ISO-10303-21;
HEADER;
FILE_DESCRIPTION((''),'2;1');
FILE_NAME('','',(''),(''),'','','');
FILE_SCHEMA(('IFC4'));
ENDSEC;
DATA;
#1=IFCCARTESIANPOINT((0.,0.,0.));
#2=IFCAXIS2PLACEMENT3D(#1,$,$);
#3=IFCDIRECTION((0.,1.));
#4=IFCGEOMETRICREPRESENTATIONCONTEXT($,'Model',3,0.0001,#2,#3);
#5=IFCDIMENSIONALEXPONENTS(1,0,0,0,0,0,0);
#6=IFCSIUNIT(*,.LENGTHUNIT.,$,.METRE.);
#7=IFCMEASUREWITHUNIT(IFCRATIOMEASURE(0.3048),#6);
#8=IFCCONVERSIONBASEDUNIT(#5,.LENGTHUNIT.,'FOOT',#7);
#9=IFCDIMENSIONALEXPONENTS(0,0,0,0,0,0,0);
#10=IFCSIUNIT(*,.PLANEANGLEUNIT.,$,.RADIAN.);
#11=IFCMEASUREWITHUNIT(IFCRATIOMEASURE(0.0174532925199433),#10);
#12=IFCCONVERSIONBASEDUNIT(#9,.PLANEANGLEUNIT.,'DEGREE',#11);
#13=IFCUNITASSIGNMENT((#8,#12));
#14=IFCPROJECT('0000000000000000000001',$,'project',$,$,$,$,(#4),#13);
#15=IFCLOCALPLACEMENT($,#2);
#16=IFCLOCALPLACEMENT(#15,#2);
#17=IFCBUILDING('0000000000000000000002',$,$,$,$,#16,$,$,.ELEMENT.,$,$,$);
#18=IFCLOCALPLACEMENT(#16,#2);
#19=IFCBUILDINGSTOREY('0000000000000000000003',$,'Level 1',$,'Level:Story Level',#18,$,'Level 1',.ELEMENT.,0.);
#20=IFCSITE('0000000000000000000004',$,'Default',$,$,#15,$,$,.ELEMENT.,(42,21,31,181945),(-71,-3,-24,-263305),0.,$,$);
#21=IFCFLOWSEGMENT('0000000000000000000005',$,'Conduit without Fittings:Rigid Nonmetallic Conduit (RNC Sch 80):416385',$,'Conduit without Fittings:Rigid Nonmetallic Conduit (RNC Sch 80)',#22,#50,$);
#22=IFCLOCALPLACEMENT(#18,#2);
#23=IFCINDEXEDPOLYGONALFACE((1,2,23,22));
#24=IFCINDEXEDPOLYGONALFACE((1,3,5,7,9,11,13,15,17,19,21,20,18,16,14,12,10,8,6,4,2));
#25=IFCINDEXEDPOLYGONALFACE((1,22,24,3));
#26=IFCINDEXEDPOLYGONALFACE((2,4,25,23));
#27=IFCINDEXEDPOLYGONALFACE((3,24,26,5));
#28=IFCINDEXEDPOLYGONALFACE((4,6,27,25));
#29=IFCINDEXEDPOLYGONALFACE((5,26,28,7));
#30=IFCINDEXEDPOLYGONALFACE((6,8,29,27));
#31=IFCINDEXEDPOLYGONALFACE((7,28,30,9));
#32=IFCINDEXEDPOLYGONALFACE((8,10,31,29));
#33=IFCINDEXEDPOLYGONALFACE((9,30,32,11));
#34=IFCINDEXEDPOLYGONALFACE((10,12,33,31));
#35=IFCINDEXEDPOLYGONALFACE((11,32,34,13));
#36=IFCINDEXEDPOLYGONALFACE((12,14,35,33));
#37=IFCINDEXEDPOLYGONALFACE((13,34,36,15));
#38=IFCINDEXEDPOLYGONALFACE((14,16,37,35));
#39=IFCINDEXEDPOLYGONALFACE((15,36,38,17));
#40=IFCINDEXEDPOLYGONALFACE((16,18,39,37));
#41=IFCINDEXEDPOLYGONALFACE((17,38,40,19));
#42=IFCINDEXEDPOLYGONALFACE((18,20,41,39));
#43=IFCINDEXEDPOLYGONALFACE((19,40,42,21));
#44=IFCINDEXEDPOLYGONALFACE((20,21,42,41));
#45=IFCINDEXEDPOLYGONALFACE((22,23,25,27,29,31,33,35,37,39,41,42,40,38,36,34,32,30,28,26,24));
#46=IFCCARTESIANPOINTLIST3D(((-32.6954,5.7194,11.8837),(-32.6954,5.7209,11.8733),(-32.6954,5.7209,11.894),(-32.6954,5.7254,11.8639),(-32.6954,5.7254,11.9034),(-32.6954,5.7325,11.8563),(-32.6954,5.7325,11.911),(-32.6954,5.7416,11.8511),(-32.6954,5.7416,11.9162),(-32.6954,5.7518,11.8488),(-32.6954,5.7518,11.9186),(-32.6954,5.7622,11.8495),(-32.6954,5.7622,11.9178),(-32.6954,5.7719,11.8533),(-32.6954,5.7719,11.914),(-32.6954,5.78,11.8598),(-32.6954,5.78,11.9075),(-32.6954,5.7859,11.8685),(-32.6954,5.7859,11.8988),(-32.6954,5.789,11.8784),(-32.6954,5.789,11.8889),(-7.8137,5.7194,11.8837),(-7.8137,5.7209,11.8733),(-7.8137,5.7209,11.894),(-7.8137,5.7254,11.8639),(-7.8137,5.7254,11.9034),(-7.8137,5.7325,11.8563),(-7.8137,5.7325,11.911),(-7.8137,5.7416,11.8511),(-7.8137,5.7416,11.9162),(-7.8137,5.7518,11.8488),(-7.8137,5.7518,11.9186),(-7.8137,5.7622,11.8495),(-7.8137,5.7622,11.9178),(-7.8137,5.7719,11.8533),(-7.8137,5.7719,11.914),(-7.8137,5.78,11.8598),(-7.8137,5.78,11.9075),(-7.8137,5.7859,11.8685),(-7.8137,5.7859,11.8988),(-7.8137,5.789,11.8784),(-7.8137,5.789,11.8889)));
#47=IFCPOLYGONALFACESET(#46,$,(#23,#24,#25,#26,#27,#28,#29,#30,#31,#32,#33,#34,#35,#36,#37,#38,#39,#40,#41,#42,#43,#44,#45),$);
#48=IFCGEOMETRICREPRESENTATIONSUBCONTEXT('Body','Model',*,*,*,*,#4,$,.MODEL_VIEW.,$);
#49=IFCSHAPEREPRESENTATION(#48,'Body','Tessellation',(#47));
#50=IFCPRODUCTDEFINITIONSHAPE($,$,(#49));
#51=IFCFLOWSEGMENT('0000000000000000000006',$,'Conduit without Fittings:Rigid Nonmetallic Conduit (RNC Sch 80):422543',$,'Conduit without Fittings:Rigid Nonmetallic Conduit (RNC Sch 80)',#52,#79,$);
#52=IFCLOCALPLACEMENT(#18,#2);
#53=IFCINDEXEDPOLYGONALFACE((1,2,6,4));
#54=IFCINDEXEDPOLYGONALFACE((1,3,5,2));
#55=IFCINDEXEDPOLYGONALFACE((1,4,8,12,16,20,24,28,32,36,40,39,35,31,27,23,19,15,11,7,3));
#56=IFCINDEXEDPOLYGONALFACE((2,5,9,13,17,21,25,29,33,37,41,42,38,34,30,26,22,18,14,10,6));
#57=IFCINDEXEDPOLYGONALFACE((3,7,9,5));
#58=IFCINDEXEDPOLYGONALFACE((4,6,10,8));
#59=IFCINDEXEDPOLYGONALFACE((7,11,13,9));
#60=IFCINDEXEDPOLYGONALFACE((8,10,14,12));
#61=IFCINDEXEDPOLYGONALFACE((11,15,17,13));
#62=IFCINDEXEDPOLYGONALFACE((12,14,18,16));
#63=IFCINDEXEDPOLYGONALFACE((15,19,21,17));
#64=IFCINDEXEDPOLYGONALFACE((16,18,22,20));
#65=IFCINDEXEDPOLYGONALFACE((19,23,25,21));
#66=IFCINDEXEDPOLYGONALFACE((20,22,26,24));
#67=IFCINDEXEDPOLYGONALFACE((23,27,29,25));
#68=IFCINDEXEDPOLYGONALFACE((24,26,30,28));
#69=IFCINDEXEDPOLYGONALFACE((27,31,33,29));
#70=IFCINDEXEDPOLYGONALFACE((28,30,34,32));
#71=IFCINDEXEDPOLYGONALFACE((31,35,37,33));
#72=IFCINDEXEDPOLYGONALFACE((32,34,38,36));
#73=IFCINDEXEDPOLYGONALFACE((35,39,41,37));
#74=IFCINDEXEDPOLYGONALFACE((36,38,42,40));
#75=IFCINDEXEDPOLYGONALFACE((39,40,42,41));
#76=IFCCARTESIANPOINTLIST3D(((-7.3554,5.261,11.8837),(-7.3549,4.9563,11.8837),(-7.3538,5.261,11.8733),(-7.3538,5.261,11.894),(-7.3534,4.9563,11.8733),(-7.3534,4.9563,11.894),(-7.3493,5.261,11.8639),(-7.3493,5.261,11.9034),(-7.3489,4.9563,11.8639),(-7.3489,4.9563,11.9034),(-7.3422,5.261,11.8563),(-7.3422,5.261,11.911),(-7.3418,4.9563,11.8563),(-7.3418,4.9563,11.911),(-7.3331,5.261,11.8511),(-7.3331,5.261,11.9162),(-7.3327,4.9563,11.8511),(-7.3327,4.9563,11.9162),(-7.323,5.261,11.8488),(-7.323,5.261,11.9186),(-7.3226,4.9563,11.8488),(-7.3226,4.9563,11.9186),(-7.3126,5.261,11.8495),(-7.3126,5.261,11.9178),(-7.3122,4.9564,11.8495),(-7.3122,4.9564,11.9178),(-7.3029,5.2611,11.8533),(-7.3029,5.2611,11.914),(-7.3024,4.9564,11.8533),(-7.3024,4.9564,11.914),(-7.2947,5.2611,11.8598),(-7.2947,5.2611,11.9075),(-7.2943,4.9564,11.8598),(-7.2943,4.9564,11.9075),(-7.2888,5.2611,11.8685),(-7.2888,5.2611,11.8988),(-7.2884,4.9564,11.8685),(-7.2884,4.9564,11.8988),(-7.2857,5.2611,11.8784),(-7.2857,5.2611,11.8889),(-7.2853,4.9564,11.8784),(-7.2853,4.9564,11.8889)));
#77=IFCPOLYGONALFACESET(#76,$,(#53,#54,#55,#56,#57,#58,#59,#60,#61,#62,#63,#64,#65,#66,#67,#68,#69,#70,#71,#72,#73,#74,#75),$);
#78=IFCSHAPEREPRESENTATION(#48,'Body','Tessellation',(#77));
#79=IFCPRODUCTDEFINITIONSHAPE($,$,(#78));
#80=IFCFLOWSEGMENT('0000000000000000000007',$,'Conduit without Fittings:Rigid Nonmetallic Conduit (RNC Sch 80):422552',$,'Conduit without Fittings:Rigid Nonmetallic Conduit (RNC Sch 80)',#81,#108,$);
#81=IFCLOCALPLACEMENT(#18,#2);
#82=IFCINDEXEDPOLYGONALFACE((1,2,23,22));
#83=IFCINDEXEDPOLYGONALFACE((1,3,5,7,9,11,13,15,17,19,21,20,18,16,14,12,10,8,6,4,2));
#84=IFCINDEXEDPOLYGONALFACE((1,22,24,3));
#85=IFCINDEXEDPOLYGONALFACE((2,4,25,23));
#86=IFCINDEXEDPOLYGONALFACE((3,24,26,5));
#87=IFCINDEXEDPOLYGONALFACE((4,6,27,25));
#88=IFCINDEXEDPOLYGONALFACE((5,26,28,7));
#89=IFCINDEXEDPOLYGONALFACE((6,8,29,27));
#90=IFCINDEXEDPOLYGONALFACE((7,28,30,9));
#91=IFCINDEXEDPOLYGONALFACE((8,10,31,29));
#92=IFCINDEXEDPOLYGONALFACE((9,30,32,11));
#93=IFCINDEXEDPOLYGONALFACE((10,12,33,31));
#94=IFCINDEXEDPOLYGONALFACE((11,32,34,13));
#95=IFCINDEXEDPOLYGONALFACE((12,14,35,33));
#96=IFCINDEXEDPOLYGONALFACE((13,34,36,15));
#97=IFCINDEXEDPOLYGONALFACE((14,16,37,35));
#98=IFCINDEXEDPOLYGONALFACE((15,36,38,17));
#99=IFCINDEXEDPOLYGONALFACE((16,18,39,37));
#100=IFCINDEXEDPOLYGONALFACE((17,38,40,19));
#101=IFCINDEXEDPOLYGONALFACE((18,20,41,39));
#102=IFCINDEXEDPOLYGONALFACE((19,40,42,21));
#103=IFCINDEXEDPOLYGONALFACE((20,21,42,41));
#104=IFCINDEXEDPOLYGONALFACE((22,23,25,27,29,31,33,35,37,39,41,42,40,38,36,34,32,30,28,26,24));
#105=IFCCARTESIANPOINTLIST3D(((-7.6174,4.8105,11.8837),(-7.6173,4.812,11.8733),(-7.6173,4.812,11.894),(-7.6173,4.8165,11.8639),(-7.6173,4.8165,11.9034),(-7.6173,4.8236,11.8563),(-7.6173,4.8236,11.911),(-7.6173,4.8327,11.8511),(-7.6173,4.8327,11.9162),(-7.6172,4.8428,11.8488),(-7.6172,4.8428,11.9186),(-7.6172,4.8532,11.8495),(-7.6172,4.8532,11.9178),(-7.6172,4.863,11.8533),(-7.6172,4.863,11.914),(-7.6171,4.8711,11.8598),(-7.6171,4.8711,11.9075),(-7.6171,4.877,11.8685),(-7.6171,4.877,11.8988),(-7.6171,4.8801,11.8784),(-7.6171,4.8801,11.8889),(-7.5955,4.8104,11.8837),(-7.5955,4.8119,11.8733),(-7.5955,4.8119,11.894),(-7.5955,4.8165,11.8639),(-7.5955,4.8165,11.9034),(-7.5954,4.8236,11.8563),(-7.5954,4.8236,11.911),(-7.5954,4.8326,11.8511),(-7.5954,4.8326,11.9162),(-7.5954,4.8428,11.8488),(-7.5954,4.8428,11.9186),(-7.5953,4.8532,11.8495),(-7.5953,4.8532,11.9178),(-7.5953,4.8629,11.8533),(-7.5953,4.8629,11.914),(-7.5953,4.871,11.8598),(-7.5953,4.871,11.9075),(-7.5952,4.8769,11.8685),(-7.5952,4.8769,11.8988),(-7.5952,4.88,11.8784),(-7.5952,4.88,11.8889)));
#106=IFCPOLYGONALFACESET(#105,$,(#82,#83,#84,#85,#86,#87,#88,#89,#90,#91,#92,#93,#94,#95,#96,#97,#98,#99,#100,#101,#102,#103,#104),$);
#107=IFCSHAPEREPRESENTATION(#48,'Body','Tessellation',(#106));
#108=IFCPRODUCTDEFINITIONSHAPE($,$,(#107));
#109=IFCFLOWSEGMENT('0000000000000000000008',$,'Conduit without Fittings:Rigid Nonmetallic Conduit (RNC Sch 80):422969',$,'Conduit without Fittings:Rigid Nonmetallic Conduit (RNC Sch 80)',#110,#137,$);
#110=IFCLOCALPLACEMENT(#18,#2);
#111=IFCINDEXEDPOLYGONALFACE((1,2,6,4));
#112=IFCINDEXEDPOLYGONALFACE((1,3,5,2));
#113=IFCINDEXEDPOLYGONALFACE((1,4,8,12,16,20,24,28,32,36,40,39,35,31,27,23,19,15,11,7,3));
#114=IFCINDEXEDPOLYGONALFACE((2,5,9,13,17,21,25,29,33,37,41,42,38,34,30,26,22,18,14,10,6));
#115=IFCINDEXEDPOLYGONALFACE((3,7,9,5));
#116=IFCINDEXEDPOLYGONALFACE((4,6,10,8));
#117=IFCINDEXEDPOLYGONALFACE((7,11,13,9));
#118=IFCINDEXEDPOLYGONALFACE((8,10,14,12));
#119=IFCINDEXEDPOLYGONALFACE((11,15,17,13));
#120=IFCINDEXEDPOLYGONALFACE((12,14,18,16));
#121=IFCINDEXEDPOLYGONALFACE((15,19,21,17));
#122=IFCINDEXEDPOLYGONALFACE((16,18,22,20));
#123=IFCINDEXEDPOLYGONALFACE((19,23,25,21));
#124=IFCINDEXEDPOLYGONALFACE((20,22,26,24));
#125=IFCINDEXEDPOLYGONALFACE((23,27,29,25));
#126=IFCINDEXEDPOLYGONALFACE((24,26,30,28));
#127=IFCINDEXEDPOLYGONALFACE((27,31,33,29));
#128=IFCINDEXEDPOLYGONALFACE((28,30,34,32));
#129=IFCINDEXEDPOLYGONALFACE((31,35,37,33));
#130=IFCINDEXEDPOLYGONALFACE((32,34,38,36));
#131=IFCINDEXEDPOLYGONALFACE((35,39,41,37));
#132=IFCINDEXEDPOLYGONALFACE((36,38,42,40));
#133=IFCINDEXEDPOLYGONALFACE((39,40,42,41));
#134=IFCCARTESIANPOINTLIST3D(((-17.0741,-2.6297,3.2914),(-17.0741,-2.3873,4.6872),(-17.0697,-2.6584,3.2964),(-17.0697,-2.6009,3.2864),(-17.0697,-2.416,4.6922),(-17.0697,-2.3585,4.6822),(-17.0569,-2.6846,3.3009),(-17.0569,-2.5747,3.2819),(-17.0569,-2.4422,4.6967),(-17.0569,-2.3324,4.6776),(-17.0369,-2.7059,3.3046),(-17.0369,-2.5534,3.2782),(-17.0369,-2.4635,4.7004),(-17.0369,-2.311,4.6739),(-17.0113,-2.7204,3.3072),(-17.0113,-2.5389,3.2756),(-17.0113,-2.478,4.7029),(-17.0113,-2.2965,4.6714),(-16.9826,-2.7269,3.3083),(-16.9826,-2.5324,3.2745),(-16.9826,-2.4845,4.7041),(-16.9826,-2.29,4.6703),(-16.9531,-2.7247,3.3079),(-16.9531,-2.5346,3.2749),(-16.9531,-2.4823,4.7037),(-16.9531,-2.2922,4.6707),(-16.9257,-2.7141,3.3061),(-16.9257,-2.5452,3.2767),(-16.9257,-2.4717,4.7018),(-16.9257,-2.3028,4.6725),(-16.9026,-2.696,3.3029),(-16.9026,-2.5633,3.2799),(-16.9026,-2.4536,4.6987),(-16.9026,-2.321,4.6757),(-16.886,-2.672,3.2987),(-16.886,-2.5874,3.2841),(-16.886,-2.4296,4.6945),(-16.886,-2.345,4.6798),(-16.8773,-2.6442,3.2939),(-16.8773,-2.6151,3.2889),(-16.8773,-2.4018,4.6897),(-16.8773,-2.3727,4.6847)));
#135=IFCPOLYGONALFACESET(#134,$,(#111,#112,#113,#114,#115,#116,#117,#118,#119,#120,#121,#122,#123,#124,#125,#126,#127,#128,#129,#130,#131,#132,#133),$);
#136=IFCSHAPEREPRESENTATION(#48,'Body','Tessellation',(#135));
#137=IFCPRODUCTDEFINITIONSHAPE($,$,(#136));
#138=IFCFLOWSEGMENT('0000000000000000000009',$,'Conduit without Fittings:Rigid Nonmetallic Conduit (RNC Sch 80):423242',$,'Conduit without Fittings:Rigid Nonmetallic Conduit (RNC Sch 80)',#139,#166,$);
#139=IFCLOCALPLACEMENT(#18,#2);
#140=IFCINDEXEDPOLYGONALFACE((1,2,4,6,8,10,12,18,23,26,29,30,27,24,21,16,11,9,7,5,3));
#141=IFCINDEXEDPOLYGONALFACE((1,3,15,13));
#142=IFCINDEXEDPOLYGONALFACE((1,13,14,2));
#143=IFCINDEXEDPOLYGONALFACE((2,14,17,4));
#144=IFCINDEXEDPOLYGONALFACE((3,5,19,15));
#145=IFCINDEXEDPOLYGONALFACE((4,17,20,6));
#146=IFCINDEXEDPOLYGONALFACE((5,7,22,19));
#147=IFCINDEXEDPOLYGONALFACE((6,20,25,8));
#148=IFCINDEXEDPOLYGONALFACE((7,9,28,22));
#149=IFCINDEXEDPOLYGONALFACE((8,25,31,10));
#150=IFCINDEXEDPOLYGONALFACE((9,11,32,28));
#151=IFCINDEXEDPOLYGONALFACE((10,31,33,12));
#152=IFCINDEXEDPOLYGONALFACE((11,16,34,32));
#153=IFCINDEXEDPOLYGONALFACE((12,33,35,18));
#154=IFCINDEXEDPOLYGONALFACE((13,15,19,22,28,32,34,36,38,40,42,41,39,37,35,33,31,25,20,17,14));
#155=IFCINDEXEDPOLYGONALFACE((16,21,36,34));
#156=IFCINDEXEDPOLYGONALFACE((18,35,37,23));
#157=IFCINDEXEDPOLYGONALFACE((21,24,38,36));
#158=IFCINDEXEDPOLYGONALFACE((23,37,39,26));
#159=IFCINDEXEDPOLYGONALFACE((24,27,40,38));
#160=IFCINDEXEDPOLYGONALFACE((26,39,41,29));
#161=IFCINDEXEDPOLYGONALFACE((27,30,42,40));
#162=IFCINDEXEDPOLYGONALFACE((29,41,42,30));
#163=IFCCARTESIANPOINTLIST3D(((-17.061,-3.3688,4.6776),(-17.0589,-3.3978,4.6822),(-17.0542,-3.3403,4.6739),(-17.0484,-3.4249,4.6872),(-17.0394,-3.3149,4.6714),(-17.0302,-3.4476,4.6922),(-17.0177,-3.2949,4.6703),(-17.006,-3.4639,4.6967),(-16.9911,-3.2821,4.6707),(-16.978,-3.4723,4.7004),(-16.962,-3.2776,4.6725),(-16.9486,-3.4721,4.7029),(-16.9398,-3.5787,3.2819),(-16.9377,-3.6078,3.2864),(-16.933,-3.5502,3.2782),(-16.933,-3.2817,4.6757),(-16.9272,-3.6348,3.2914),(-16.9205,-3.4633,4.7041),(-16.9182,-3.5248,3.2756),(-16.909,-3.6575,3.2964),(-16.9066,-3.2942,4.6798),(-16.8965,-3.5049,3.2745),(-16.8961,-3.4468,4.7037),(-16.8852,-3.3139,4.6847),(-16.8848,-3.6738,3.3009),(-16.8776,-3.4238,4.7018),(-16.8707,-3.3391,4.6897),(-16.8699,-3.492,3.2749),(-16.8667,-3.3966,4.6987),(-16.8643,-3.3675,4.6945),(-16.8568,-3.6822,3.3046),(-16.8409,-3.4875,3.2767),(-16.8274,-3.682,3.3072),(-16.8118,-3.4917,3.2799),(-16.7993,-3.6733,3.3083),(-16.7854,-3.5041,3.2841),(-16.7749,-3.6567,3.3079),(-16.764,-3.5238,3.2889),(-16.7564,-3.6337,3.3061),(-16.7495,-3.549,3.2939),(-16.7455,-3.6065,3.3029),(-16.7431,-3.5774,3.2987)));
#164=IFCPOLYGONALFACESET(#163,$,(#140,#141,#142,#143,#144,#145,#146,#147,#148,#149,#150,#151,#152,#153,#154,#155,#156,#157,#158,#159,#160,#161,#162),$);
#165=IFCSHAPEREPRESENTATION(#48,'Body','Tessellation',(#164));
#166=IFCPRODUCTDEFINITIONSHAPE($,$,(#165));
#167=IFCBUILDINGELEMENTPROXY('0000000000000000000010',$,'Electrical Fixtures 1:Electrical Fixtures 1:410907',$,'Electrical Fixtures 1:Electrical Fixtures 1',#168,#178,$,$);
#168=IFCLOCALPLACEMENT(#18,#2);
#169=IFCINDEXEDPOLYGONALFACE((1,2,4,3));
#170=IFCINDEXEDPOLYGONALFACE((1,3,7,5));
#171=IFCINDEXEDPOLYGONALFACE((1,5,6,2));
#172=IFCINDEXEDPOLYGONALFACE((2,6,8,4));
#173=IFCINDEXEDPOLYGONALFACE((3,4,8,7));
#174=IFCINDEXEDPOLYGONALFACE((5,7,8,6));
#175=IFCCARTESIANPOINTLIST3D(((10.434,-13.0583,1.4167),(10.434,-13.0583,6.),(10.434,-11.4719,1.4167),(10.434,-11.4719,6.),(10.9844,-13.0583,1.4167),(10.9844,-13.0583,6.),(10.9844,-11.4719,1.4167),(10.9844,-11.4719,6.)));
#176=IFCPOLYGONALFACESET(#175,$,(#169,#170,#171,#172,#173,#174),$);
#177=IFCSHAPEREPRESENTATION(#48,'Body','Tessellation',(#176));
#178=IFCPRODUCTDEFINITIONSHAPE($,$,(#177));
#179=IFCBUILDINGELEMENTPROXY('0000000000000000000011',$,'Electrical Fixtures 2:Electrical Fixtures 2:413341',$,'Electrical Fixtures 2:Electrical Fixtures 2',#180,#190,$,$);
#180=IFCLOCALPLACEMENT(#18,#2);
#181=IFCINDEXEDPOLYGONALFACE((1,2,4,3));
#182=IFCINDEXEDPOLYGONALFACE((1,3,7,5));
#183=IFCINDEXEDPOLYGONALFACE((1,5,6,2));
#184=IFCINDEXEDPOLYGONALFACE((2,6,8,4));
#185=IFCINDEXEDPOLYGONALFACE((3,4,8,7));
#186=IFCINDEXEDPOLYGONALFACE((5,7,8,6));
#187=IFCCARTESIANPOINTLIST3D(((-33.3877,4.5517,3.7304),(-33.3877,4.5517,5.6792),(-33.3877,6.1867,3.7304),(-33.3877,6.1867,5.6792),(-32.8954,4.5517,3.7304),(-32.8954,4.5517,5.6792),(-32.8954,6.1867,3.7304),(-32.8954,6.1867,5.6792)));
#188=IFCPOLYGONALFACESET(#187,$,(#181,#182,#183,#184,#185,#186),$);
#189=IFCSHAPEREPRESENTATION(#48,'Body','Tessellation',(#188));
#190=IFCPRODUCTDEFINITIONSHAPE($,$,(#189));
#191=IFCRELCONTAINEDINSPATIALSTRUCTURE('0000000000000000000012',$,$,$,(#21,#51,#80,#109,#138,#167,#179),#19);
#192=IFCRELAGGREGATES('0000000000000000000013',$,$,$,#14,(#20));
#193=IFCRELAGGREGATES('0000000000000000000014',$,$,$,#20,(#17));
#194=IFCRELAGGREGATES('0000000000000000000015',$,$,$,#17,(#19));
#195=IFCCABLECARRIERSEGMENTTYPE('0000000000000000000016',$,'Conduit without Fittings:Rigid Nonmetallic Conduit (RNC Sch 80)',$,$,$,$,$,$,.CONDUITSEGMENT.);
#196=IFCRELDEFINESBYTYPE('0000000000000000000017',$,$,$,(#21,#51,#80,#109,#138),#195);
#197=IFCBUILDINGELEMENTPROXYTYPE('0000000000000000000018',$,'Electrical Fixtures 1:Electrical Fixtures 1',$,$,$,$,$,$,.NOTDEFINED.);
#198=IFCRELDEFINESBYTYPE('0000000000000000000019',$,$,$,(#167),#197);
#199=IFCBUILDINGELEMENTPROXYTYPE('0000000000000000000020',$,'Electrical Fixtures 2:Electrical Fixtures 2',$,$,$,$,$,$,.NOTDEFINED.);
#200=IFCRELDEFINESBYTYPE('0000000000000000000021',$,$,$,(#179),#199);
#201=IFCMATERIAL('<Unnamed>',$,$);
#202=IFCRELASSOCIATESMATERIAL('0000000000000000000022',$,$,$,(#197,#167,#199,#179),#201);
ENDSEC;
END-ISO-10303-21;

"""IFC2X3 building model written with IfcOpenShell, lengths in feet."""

from ifc_helpers import new_model, entity, si_unit, converted_unit, direction, frame, frame_2d, origin, origin_2d_with_axis, place, context, subcontext, project, spatial, rectangle, circle, extrude, source, transform, mapped, material, type_object, type_shapes, element, save


model = new_model("IFC2X3")

# Units and contexts
model_context = context("Model", 3, precision=0.0001, world=origin(), true_north=direction((0.0, 1.0)))
body_context = subcontext(model_context, "Body", "Model", "MODEL_VIEW")
ifc_project = project(units=[converted_unit("LENGTHUNIT", "FOOT", entity("IfcRatioMeasure", 0.3048), si_unit("LENGTHUNIT", "METRE"), dimensions=[1, 0, 0, 0, 0, 0, 0]), converted_unit("PLANEANGLEUNIT", "DEGREE", entity("IfcRatioMeasure", 0.0174532925199433), si_unit("PLANEANGLEUNIT", "RADIAN"), dimensions=[0, 0, 0, 0, 0, 0, 0])], contexts=[model_context])

# Site, building, storey
site_placement = place(None, origin())
site = spatial("IfcSite", under=ifc_project, at=site_placement, Name="Default", CompositionType="ELEMENT", RefLatitude=(42, 21, 31, 181945), RefLongitude=(-71, -3, -24, -263305), RefElevation=0.0)
building_placement = place(site_placement, origin())
building = spatial("IfcBuilding", under=site, at=building_placement, CompositionType="ELEMENT")
storey_placement = place(building_placement, origin())
storey = spatial("IfcBuildingStorey", under=building, at=storey_placement, Name="Level 1", ObjectType="Level:Story Level", LongName="Level 1", CompositionType="ELEMENT", Elevation=0.0)

# Flow segments
cable_carrier_segment_type = type_object("IfcCableCarrierSegmentType", Name="Conduit without Fittings:Rigid Nonmetallic Conduit (RNC Sch 80)", PredefinedType="CONDUITSEGMENT")
flow_segment_1_placement = place(storey_placement, origin())
element("IfcFlowSegment", 1, at=flow_segment_1_placement, inside=storey, type_object=cable_carrier_segment_type, Name="Conduit without Fittings:Rigid Nonmetallic Conduit (RNC Sch 80):416385", ObjectType="Conduit without Fittings:Rigid Nonmetallic Conduit (RNC Sch 80)", context=body_context, shape_type="SweptSolid", body=[
    extrude(circle(Radius=0.035, at=origin_2d_with_axis()), frame((-32.6954, 5.7544, 11.8837), z_axis=(1.0, 0.0, 0.0), x_axis=(0.0, -1.0, 0.0)), (0.0, 0.0, 1.0), 24.8817),
])
flow_segment_2_placement = place(storey_placement, origin())
element("IfcFlowSegment", 2, at=flow_segment_2_placement, inside=storey, type_object=cable_carrier_segment_type, Name="Conduit without Fittings:Rigid Nonmetallic Conduit (RNC Sch 80):422543", ObjectType="Conduit without Fittings:Rigid Nonmetallic Conduit (RNC Sch 80)", context=body_context, shape_type="SweptSolid", body=[
    extrude(circle(Radius=0.035, at=origin_2d_with_axis()), frame((-7.3204, 5.261, 11.8837), z_axis=(0.001347, -0.999999, 0.0), x_axis=(-0.999999, -0.001347, 0.0)), (0.0, 0.0, 1.0), 0.3047),
])
flow_segment_3_placement = place(storey_placement, origin())
element("IfcFlowSegment", 3, at=flow_segment_3_placement, inside=storey, type_object=cable_carrier_segment_type, Name="Conduit without Fittings:Rigid Nonmetallic Conduit (RNC Sch 80):422552", ObjectType="Conduit without Fittings:Rigid Nonmetallic Conduit (RNC Sch 80)", context=body_context, shape_type="SweptSolid", body=[
    extrude(circle(Radius=0.035, at=origin_2d_with_axis()), frame((-7.6172, 4.8455, 11.8837), z_axis=(0.999993, -0.003666, 0.0), x_axis=(-0.003666, -0.999993, 0.0)), (0.0, 0.0, 1.0), 0.0219),
])
flow_segment_4_placement = place(storey_placement, origin())
element("IfcFlowSegment", 4, at=flow_segment_4_placement, inside=storey, type_object=cable_carrier_segment_type, Name="Conduit without Fittings:Rigid Nonmetallic Conduit (RNC Sch 80):422969", ObjectType="Conduit without Fittings:Rigid Nonmetallic Conduit (RNC Sch 80)", context=body_context, shape_type="SweptSolid", body=[
    extrude(circle(Radius=0.099, at=frame_2d((0.0, 0.0), x_axis=(1.0, 0.0))), frame((-16.9752, -2.6297, 3.2914), z_axis=(0.0, 0.171097, 0.985254), x_axis=(-1.0, 0.0, 0.0)), (0.0, 0.0, 1.0), 1.4167),
])
flow_segment_5_placement = place(storey_placement, origin())
element("IfcFlowSegment", 5, at=flow_segment_5_placement, inside=storey, type_object=cable_carrier_segment_type, Name="Conduit without Fittings:Rigid Nonmetallic Conduit (RNC Sch 80):423242", ObjectType="Conduit without Fittings:Rigid Nonmetallic Conduit (RNC Sch 80)", context=body_context, shape_type="SweptSolid", body=[
    extrude(circle(Radius=0.099, at=frame_2d((0.0, 0.0), x_axis=(1.0, 0.0))), frame((-16.8415, -3.5854, 3.2914), z_axis=(-0.085549, 0.148175, 0.985254), x_axis=(-0.866025, -0.5, 0.0)), (0.0, 0.0, 1.0), 1.4167),
])

# Building element proxies
ifc_material_1 = material(Name="<Unnamed>")
building_element_proxy_type_1 = type_object("IfcBuildingElementProxyType", Name="Electrical Fixtures 1:Electrical Fixtures 1", PredefinedType="NOTDEFINED", material=ifc_material_1)
shared_shape_1 = source(origin(), body_context, "Body", "SweptSolid", [
    extrude(rectangle(XDim=1.5864, YDim=0.5504, at=frame_2d((0.0, 0.0), x_axis=(1.0, 0.0))), frame((10.7092, -12.2651, 1.4167), z_axis=(0.0, 0.0, 1.0), x_axis=(0.0, -1.0, 0.0)), (0.0, 0.0, 1.0), 4.5833),
])
type_shapes(building_element_proxy_type_1, [shared_shape_1])
proxy_1_placement = place(storey_placement, origin())
element("IfcBuildingElementProxy", 6, at=proxy_1_placement, inside=storey, type_object=building_element_proxy_type_1, material=ifc_material_1, Name="Electrical Fixtures 1:Electrical Fixtures 1:410907", ObjectType="Electrical Fixtures 1:Electrical Fixtures 1", context=body_context, shape_type="MappedRepresentation", body=[
    mapped(shared_shape_1, transform((0.0, 0.0, 0.0), scale=1.0)),
])
building_element_proxy_type_2 = type_object("IfcBuildingElementProxyType", Name="Electrical Fixtures 2:Electrical Fixtures 2", PredefinedType="NOTDEFINED", material=ifc_material_1)
shared_shape_2 = source(origin(), body_context, "Body", "SweptSolid", [
    extrude(rectangle(XDim=0.4923, YDim=1.6351, at=origin_2d_with_axis()), frame((-33.1415, 5.3692, 3.7304), z_axis=(0.0, 0.0, 1.0), x_axis=(-1.0, 0.0, 0.0)), (0.0, 0.0, 1.0), 1.9488),
])
type_shapes(building_element_proxy_type_2, [shared_shape_2])
proxy_2_placement = place(storey_placement, origin())
element("IfcBuildingElementProxy", 7, at=proxy_2_placement, inside=storey, type_object=building_element_proxy_type_2, material=ifc_material_1, Name="Electrical Fixtures 2:Electrical Fixtures 2:413341", ObjectType="Electrical Fixtures 2:Electrical Fixtures 2", context=body_context, shape_type="MappedRepresentation", body=[
    mapped(shared_shape_2, transform((0.0, 0.0, 0.0), scale=1.0)),
])

save(model, "model.ifc")
